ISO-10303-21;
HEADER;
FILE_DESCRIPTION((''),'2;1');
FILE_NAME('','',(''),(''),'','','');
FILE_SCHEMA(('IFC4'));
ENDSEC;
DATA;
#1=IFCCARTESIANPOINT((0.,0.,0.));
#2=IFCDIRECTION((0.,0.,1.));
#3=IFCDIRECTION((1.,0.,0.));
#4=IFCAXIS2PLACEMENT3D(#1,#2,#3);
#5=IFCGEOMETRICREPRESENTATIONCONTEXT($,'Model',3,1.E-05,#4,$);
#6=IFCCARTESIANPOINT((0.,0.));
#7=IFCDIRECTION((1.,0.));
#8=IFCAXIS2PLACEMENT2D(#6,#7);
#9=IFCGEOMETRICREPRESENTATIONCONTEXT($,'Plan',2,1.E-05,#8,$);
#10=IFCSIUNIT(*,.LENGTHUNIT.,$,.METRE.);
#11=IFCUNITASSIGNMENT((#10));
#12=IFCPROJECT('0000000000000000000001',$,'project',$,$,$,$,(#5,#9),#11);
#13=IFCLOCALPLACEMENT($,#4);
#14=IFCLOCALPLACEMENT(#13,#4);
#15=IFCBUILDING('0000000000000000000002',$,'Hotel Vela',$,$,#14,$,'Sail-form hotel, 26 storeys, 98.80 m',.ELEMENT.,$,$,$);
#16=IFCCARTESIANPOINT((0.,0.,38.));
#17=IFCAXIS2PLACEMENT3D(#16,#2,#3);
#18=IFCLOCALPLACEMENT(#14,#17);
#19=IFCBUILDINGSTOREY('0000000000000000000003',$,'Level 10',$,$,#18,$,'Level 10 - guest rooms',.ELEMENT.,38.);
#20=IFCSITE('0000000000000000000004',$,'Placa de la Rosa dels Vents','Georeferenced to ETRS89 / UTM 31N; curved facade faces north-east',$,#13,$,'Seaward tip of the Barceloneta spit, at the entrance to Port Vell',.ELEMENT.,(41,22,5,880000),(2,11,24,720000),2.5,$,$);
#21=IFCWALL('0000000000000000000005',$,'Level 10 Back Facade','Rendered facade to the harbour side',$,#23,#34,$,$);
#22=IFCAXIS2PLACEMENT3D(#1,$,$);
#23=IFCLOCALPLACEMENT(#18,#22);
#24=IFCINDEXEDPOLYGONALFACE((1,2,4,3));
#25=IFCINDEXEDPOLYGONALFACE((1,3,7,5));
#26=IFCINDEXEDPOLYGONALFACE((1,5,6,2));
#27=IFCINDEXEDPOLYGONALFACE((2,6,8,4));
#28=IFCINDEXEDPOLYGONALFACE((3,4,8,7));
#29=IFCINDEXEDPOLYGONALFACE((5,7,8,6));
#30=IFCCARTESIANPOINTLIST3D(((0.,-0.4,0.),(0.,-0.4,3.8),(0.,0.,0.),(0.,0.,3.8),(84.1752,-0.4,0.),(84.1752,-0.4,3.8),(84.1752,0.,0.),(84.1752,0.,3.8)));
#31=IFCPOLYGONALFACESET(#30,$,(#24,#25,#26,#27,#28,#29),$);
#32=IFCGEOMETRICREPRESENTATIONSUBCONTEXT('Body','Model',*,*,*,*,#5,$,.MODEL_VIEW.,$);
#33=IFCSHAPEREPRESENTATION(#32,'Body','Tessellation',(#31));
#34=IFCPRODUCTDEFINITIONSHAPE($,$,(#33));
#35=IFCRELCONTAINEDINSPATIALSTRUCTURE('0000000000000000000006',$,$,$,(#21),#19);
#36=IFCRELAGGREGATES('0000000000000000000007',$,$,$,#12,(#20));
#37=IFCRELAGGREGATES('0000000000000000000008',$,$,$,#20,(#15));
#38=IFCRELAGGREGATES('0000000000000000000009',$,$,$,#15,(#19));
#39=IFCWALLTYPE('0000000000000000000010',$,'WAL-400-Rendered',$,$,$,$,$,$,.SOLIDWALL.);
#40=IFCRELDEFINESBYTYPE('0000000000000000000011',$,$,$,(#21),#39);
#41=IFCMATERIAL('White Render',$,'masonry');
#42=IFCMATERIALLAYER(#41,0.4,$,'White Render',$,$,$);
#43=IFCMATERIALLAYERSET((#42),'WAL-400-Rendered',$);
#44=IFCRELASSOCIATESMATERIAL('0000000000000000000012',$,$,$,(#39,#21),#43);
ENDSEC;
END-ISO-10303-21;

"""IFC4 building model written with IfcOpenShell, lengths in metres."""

from ifc_helpers import new_model, si_unit, frame, origin_with_axes, origin_2d_with_axis, place, context, subcontext, project, spatial, line, indexed_curve, outline, extrude, material, layer, layer_set, layer_usage, type_object, element, save


model = new_model("IFC4")

# Units and contexts
model_context = context("Model", 3, precision=1e-05, world=origin_with_axes())
plan_context = context("Plan", 2, precision=1e-05, world=origin_2d_with_axis())
body_context = subcontext(model_context, "Body", "Model", "MODEL_VIEW")
ifc_project = project(units=[si_unit("LENGTHUNIT", "METRE")], contexts=[model_context, plan_context])

# Site, building, storey
site_placement = place(None, origin_with_axes())
site = spatial("IfcSite", under=ifc_project, at=site_placement, Name="Placa de la Rosa dels Vents", Description="Georeferenced to ETRS89 / UTM 31N; curved facade faces north-east", LongName="Seaward tip of the Barceloneta spit, at the entrance to Port Vell", CompositionType="ELEMENT", RefLatitude=(41, 22, 5, 880000), RefLongitude=(2, 11, 24, 720000), RefElevation=2.5)
building_placement = place(site_placement, origin_with_axes())
building = spatial("IfcBuilding", under=site, at=building_placement, Name="Hotel Vela", LongName="Sail-form hotel, 26 storeys, 98.80 m", CompositionType="ELEMENT")
storey_placement = place(building_placement, frame((0.0, 0.0, 38.0), z_axis=(0.0, 0.0, 1.0), x_axis=(1.0, 0.0, 0.0)))
storey = spatial("IfcBuildingStorey", under=building, at=storey_placement, Name="Level 10", LongName="Level 10 - guest rooms", CompositionType="ELEMENT", Elevation=38.0)

# Wall
ifc_material_1 = material(Name="White Render", Category="masonry")
ifc_layer_1 = layer(ifc_material_1, 0.4, Name="White Render")
ifc_layer_set_1 = layer_set([ifc_layer_1], Name="WAL-400-Rendered")
ifc_layer_usage_1 = layer_usage(ifc_layer_set_1, "AXIS2", "POSITIVE", 0.0)
wall_type = type_object("IfcWallType", Name="WAL-400-Rendered", PredefinedType="SOLIDWALL", material=ifc_layer_set_1)
wall_placement = place(storey_placement, frame((0.0, -0.4, 0.0), z_axis=(0.0, 0.0, 1.0), x_axis=(1.0, 0.0, 0.0)))
element("IfcWall", 1, at=wall_placement, inside=storey, type_object=wall_type, material=ifc_layer_usage_1, Name="Level 10 Back Facade", Description="Rendered facade to the harbour side", context=body_context, shape_type="SweptSolid", body=[
    extrude(outline(indexed_curve([(0.0, 0.0), (84.1752, 0.0), (84.1752, 0.4), (0.0, 0.4)], segments=[line(1, 2, 3, 4, 1)])), origin_with_axes(), (0.0, 0.0, 1.0), 3.8),
])

save(model, "model.ifc")
